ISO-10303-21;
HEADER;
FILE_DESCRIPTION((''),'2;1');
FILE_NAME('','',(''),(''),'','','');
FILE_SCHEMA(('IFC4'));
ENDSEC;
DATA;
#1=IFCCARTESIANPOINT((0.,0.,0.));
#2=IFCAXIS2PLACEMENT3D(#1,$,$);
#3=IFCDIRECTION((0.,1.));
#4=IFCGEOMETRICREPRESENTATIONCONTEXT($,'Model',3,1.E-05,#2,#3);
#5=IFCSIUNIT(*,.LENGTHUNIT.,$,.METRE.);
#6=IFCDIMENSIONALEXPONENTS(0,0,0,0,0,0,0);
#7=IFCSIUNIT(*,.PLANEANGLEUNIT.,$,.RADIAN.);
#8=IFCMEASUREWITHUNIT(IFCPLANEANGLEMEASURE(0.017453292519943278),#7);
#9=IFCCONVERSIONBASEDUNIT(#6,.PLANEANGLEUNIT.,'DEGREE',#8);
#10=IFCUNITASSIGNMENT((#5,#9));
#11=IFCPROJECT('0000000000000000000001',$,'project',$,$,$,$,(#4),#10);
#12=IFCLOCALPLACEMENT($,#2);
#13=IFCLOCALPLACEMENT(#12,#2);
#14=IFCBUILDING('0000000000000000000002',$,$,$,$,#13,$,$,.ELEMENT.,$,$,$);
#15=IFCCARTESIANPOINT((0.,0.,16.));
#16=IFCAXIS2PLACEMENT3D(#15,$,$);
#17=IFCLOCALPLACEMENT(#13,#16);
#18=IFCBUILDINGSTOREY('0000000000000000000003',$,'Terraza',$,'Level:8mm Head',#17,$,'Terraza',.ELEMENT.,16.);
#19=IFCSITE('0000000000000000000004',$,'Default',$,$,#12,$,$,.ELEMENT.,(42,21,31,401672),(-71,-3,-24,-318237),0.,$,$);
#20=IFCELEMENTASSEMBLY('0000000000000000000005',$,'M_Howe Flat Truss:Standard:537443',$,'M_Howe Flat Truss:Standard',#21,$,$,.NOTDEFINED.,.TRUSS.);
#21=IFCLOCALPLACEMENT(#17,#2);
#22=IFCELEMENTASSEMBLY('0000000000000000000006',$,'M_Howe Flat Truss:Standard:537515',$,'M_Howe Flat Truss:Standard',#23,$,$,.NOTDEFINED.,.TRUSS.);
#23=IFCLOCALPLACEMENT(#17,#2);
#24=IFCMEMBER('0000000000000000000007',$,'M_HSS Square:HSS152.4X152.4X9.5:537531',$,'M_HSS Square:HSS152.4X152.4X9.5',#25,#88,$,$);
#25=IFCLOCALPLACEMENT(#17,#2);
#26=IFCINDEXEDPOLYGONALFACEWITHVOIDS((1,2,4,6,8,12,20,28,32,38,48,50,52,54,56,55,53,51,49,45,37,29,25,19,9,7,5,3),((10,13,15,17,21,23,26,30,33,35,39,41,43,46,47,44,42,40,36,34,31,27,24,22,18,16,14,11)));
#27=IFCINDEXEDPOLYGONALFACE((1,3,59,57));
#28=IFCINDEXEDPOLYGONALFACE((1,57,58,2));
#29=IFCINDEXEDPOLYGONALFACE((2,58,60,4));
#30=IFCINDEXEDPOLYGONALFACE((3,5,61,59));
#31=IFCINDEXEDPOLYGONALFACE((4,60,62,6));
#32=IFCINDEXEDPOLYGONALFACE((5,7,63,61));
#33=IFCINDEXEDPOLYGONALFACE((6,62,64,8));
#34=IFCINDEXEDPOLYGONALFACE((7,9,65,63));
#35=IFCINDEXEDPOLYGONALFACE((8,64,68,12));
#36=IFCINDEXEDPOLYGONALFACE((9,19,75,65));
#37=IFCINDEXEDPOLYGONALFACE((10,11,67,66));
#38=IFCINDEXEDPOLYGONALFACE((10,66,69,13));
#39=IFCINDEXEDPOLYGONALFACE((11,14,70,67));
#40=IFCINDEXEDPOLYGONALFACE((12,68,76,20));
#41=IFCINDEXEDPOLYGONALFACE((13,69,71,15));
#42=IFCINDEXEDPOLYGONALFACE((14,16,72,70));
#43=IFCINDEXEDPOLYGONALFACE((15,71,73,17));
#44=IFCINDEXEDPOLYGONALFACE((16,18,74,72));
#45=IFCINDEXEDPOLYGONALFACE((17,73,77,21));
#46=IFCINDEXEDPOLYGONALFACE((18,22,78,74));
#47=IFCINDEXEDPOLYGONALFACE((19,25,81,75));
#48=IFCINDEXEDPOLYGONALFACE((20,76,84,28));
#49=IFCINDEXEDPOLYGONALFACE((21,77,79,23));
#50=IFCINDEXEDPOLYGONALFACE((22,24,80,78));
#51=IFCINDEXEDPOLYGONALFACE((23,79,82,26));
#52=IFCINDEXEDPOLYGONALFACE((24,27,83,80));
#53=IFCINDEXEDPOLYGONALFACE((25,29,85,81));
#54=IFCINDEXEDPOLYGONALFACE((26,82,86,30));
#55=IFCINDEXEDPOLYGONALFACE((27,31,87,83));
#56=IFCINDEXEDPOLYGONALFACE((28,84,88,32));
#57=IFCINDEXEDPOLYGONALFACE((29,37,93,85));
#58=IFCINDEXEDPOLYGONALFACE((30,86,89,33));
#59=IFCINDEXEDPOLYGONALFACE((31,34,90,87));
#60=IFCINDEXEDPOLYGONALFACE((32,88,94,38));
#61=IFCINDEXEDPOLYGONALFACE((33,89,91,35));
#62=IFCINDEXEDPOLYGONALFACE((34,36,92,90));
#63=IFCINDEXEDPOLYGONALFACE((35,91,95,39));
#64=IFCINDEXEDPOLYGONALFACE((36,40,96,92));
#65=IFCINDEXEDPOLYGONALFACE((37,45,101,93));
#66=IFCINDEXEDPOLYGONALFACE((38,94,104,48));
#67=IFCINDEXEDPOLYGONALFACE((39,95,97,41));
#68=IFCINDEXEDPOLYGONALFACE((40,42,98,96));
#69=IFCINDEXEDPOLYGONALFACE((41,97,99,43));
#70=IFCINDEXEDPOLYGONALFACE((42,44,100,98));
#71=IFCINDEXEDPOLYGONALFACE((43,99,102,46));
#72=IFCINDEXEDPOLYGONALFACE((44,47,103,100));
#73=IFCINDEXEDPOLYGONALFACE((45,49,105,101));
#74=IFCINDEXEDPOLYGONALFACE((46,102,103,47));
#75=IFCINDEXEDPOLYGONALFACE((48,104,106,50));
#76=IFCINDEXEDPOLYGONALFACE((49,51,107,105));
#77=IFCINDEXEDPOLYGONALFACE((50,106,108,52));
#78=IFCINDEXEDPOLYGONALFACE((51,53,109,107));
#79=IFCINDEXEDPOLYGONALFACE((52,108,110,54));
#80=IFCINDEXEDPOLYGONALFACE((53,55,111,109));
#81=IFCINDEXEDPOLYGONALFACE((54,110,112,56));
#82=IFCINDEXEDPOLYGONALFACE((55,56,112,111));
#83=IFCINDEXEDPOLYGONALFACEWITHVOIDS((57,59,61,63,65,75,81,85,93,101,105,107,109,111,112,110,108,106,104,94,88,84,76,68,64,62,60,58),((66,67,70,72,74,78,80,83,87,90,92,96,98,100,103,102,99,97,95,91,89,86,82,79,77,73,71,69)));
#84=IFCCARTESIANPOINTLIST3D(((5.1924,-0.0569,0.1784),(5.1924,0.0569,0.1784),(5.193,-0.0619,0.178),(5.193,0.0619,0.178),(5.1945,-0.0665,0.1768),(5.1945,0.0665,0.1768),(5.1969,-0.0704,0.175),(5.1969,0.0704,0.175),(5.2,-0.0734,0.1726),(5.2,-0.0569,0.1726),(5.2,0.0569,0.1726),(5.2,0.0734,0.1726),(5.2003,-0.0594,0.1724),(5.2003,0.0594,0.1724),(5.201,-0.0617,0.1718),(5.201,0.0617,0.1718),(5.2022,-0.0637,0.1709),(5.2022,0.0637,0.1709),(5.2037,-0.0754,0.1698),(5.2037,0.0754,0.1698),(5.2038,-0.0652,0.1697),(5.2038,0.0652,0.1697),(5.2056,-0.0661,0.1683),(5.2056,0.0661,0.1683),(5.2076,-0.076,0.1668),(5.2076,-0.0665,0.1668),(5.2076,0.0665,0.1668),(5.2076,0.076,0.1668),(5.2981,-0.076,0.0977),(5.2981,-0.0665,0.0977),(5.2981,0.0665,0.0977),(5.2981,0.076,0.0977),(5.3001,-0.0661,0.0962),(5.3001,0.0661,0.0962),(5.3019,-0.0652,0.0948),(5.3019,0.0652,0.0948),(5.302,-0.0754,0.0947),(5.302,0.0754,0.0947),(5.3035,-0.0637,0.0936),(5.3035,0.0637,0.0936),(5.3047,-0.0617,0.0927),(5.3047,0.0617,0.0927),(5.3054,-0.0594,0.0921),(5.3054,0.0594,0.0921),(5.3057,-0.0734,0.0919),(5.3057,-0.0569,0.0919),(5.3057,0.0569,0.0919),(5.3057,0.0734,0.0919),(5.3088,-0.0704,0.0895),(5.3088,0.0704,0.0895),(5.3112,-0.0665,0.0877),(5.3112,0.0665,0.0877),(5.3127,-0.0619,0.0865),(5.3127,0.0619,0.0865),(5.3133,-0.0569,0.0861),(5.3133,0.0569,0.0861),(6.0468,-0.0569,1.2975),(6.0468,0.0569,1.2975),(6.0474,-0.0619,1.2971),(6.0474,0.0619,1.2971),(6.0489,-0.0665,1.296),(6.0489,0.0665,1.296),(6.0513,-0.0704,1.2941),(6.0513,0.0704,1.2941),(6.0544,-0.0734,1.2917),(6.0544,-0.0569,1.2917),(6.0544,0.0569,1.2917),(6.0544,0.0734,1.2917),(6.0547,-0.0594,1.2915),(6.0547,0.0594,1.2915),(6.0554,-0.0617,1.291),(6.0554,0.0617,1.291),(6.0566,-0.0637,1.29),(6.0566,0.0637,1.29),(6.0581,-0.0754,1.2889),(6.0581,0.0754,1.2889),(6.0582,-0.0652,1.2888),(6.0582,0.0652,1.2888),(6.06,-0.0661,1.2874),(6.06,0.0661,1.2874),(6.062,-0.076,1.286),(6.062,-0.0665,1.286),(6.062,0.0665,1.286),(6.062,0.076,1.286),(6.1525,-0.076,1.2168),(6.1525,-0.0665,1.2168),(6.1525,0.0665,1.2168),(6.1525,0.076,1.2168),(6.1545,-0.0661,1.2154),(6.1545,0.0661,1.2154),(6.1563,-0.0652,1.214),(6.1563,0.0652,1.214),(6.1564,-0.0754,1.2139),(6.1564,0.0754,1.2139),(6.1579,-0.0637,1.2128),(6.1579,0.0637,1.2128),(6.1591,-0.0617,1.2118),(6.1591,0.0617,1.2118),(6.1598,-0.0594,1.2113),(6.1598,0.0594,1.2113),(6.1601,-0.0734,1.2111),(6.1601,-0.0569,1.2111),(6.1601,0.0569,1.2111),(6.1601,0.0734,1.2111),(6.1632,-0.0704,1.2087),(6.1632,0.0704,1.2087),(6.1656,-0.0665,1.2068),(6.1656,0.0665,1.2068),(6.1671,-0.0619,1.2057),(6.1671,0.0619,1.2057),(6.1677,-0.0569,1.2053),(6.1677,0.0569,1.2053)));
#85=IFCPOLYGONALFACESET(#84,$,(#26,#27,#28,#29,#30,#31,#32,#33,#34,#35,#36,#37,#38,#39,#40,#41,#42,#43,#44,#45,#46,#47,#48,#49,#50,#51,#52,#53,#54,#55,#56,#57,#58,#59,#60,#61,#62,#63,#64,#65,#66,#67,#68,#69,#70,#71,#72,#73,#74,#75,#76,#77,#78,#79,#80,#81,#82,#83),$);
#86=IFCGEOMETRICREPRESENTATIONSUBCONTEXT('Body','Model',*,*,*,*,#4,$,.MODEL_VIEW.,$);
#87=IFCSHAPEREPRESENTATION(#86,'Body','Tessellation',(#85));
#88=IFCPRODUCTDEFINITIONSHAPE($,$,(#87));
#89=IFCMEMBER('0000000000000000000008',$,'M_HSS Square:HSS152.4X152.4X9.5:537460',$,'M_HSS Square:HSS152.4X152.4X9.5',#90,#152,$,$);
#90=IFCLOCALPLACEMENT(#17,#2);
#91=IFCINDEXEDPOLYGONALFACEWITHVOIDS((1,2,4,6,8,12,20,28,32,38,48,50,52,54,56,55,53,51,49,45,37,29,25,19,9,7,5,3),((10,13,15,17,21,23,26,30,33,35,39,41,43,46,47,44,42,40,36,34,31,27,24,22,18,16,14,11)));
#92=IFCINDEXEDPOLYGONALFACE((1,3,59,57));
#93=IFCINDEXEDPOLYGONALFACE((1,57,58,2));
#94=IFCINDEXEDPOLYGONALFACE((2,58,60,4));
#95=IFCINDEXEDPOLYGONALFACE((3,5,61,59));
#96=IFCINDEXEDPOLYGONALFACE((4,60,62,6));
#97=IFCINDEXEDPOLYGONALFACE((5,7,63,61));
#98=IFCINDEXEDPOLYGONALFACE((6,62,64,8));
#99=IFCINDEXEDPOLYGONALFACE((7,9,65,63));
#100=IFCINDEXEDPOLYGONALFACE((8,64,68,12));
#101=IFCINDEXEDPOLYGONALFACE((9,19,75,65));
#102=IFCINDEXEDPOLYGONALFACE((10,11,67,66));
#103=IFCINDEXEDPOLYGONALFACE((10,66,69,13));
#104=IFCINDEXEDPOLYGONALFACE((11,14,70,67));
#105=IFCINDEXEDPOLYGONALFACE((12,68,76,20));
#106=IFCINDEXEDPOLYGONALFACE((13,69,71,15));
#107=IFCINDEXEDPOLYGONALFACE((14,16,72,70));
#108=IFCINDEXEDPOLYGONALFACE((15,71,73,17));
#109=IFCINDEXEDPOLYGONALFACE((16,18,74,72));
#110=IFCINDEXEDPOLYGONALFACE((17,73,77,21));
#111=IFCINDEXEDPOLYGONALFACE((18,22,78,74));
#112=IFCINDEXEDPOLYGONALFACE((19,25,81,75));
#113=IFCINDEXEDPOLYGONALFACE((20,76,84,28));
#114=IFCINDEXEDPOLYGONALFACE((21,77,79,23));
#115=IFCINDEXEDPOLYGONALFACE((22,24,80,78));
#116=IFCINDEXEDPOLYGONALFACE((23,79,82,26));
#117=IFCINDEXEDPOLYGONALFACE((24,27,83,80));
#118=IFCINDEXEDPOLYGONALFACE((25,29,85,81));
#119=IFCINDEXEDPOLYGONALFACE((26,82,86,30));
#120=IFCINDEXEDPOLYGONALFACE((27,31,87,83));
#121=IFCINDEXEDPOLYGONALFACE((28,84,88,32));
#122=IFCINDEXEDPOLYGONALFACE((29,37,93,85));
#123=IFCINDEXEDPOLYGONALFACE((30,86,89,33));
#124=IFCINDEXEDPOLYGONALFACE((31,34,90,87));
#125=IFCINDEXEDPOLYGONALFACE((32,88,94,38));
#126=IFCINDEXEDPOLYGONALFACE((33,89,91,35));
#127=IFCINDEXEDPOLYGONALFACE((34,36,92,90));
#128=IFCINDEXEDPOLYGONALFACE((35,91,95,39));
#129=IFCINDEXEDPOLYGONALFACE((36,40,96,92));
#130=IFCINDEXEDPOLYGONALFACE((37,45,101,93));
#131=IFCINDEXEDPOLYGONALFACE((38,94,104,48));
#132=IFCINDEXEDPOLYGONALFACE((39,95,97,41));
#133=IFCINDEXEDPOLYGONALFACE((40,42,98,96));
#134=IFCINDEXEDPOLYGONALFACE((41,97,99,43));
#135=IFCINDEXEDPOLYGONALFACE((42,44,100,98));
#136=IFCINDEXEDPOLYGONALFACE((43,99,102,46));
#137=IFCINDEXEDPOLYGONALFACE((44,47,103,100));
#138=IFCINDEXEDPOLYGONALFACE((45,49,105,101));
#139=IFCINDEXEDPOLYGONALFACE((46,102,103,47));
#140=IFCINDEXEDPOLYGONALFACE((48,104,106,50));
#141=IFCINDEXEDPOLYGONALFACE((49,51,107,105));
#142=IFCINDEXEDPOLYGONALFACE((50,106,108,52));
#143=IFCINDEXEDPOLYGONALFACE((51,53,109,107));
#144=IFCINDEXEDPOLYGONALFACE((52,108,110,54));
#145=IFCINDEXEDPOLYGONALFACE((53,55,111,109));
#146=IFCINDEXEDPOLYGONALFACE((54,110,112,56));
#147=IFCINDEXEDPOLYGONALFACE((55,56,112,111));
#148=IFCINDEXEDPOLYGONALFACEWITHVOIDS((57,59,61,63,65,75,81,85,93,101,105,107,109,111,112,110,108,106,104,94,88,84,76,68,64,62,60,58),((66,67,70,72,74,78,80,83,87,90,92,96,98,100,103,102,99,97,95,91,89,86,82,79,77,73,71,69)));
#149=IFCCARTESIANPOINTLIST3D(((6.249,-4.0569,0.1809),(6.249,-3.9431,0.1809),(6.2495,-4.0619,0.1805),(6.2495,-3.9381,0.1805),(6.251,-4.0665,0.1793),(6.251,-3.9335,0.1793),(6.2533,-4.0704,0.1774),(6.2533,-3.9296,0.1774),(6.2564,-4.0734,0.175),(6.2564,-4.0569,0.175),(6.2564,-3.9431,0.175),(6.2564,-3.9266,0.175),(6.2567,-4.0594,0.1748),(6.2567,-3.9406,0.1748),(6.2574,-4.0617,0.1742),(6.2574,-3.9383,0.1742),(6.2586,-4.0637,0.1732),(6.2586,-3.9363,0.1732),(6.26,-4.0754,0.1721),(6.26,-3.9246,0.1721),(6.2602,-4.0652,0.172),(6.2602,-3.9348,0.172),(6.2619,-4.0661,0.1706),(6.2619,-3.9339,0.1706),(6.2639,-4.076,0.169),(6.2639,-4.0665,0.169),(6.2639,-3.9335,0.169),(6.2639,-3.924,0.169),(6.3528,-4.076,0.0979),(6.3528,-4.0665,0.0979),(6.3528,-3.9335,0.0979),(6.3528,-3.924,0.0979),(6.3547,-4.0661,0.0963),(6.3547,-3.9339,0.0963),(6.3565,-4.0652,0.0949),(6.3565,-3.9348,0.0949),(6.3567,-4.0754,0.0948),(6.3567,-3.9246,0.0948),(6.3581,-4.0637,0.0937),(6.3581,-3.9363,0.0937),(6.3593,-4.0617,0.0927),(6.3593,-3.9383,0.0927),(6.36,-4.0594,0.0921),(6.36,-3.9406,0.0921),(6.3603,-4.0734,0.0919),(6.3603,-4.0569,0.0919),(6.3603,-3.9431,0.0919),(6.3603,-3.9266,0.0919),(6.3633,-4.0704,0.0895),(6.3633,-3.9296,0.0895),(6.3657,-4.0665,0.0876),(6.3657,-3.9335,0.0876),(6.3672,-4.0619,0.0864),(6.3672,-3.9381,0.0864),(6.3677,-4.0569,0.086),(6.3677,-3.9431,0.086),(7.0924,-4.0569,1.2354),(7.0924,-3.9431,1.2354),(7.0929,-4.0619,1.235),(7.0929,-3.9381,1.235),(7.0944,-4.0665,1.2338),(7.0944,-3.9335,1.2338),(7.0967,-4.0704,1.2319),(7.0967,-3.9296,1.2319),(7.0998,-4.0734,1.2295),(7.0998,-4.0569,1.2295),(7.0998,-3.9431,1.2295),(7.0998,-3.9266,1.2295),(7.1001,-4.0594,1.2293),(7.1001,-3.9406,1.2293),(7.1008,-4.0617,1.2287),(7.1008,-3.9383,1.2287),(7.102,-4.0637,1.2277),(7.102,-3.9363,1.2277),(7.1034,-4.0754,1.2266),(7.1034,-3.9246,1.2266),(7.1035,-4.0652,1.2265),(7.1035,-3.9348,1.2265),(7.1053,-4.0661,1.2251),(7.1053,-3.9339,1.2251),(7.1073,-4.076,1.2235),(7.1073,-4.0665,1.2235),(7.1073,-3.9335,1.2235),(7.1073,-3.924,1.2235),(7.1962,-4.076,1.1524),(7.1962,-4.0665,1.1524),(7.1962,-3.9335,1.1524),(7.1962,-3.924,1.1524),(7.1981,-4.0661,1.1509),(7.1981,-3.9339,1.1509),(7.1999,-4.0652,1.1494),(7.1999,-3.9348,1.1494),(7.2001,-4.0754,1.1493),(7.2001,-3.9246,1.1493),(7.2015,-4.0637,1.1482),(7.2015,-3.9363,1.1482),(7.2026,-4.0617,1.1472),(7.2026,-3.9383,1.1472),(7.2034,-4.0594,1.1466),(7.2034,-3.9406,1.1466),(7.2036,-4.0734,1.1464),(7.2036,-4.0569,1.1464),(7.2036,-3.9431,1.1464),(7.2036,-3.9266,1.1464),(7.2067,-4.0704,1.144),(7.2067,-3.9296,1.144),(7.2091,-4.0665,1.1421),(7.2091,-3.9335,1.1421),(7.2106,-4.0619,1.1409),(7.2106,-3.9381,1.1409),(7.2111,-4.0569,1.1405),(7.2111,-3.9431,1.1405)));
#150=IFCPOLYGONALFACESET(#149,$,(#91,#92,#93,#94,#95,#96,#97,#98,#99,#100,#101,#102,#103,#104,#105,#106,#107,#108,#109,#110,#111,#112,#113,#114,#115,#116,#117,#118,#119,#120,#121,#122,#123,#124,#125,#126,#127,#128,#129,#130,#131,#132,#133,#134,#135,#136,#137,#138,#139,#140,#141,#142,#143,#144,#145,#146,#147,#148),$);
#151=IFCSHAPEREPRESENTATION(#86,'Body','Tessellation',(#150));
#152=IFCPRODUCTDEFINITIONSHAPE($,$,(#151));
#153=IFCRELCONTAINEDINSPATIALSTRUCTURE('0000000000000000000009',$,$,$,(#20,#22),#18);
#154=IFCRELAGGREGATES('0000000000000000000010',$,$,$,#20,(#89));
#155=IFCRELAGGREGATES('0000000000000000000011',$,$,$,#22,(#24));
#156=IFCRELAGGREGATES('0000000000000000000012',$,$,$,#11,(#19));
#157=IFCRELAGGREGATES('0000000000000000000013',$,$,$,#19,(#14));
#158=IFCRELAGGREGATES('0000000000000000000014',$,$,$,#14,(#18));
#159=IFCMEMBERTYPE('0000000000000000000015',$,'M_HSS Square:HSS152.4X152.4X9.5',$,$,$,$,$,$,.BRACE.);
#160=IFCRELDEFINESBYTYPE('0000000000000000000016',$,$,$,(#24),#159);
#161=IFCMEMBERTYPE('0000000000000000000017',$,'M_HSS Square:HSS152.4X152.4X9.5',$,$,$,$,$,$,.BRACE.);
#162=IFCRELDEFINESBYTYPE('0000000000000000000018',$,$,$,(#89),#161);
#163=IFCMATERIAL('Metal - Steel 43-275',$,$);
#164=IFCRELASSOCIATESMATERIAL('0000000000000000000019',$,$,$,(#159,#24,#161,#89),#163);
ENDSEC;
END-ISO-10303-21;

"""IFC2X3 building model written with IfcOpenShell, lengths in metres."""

from ifc_helpers import new_model, entity, si_unit, converted_unit, direction, frame, frame_2d, origin, place, context, subcontext, project, spatial, polyline, circle_curve, parameter, trimmed, segment, composite_curve, outline, extrude, source, transform, mapped, material, type_object, type_shapes, element, aggregate, save


model = new_model("IFC2X3")

# Units and contexts
model_context = context("Model", 3, precision=1e-05, world=origin(), true_north=direction((0.0, 1.0)))
body_context = subcontext(model_context, "Body", "Model", "MODEL_VIEW")
ifc_project = project(units=[si_unit("LENGTHUNIT", "METRE"), converted_unit("PLANEANGLEUNIT", "DEGREE", entity("IfcPlaneAngleMeasure", 0.017453292519943278), si_unit("PLANEANGLEUNIT", "RADIAN"), dimensions=[0, 0, 0, 0, 0, 0, 0])], contexts=[model_context])

# Site, building, storey
site_placement = place(None, origin())
site = spatial("IfcSite", under=ifc_project, at=site_placement, Name="Default", CompositionType="ELEMENT", RefLatitude=(42, 21, 31, 401672), RefLongitude=(-71, -3, -24, -318237), RefElevation=0.0)
building_placement = place(site_placement, origin())
building = spatial("IfcBuilding", under=site, at=building_placement, CompositionType="ELEMENT")
storey_placement = place(building_placement, frame((0.0, 0.0, 16.0)))
storey = spatial("IfcBuildingStorey", under=building, at=storey_placement, Name="Terraza", ObjectType="Level:8mm Head", LongName="Terraza", CompositionType="ELEMENT", Elevation=16.0)

# Element assemblies
ifc_material_1 = material(Name="Metal - Steel 43-275")
assembly_1_placement = place(storey_placement, origin())
assembly_1 = element("IfcElementAssembly", 1, at=assembly_1_placement, inside=storey, Name="M_Howe Flat Truss:Standard:537443", ObjectType="M_Howe Flat Truss:Standard", AssemblyPlace="NOTDEFINED", PredefinedType="TRUSS")
assembly_2_placement = place(storey_placement, origin())
assembly_2 = element("IfcElementAssembly", 2, at=assembly_2_placement, inside=storey, Name="M_Howe Flat Truss:Standard:537515", ObjectType="M_Howe Flat Truss:Standard", AssemblyPlace="NOTDEFINED", PredefinedType="TRUSS")

# Members
member_type_1 = type_object("IfcMemberType", Name="M_HSS Square:HSS152.4X152.4X9.5", PredefinedType="BRACE", material=ifc_material_1)
shared_shape_1 = source(origin(), body_context, "Body", "SweptSolid", [
    extrude(outline(composite_curve([segment(polyline([(-0.0569, -0.076), (0.0569, -0.076)]), True, "CONTINUOUS"), segment(trimmed(circle_curve(frame_2d((0.0569, -0.0569), x_axis=(0.0, 1.0)), 0.0191), [parameter(180.0)], [parameter(270.0)], True, "PARAMETER"), True, "CONTINUOUS"), segment(polyline([(0.076, -0.0569), (0.076, 0.0569)]), True, "CONTINUOUS"), segment(trimmed(circle_curve(frame_2d((0.0569, 0.0569), x_axis=(0.0, 1.0)), 0.0191), [parameter(270.0)], [parameter(0.0)], True, "PARAMETER"), True, "CONTINUOUS"), segment(polyline([(0.0569, 0.076), (-0.0569, 0.076)]), True, "CONTINUOUS"), segment(trimmed(circle_curve(frame_2d((-0.0569, 0.0569), x_axis=(0.0, 1.0)), 0.0191), [parameter(0.0)], [parameter(90.0)], True, "PARAMETER"), True, "CONTINUOUS"), segment(polyline([(-0.076, 0.0569), (-0.076, -0.0569)]), True, "CONTINUOUS"), segment(trimmed(circle_curve(frame_2d((-0.0569, -0.0569), x_axis=(0.0, 1.0)), 0.0191), [parameter(90.0)], [parameter(180.0)], True, "PARAMETER"), True, "CONTINUOUS")], self_intersect=False), holes=[composite_curve([segment(trimmed(circle_curve(frame_2d((-0.0569, 0.0569), x_axis=(0.0, 1.0)), 0.0095), [parameter(360.0)], [parameter(90.0)], True, "PARAMETER"), False, "CONTINUOUS"), segment(polyline([(-0.0569, 0.0665), (0.0569, 0.0665)]), True, "CONTINUOUS"), segment(trimmed(circle_curve(frame_2d((0.0569, 0.0569), x_axis=(0.0, 1.0)), 0.0095), [parameter(270.0)], [parameter(360.0)], True, "PARAMETER"), False, "CONTINUOUS"), segment(polyline([(0.0665, 0.0569), (0.0665, -0.0569)]), True, "CONTINUOUS"), segment(trimmed(circle_curve(frame_2d((0.0569, -0.0569), x_axis=(0.0, 1.0)), 0.0095), [parameter(180.0)], [parameter(270.0)], True, "PARAMETER"), False, "CONTINUOUS"), segment(polyline([(0.0569, -0.0665), (-0.0569, -0.0665)]), True, "CONTINUOUS"), segment(trimmed(circle_curve(frame_2d((-0.0569, -0.0569), x_axis=(0.0, 1.0)), 0.0095), [parameter(90.0)], [parameter(180.0)], True, "PARAMETER"), False, "CONTINUOUS"), segment(polyline([(-0.0665, -0.0569), (-0.0665, 0.0569)]), True, "CONTINUOUS")], self_intersect=False)]), frame((-0.6986, 0.0, 0.0), z_axis=(1.0, 0.0, 0.0), x_axis=(0.0, 0.0, -1.0)), (0.0, 0.0, 1.0), 1.408),
])
type_shapes(member_type_1, [shared_shape_1])
member_1_placement = place(assembly_2_placement, frame((5.6767, 0.0, 0.6875), z_axis=(0.794843, 0.0, -0.606815), x_axis=(0.606815, 0.0, 0.794843)))
member_1 = element("IfcMember", 3, at=member_1_placement, type_object=member_type_1, material=ifc_material_1, Name="M_HSS Square:HSS152.4X152.4X9.5:537531", ObjectType="M_HSS Square:HSS152.4X152.4X9.5", context=body_context, shape_type="MappedRepresentation", body=[
    mapped(shared_shape_1, transform((0.0, 0.0, 0.0), scale=1.0)),
])
member_type_2 = type_object("IfcMemberType", Name="M_HSS Square:HSS152.4X152.4X9.5", PredefinedType="BRACE", material=ifc_material_1)
shared_shape_2 = source(origin(), body_context, "Body", "SweptSolid", [
    extrude(outline(composite_curve([segment(polyline([(-0.0569, -0.076), (0.0569, -0.076)]), True, "CONTINUOUS"), segment(trimmed(circle_curve(frame_2d((0.0569, -0.0569), x_axis=(0.0, 1.0)), 0.0191), [parameter(180.0)], [parameter(270.0)], True, "PARAMETER"), True, "CONTINUOUS"), segment(polyline([(0.076, -0.0569), (0.076, 0.0569)]), True, "CONTINUOUS"), segment(trimmed(circle_curve(frame_2d((0.0569, 0.0569), x_axis=(0.0, 1.0)), 0.0191), [parameter(270.0)], [parameter(0.0)], True, "PARAMETER"), True, "CONTINUOUS"), segment(polyline([(0.0569, 0.076), (-0.0569, 0.076)]), True, "CONTINUOUS"), segment(trimmed(circle_curve(frame_2d((-0.0569, 0.0569), x_axis=(0.0, 1.0)), 0.0191), [parameter(0.0)], [parameter(90.0)], True, "PARAMETER"), True, "CONTINUOUS"), segment(polyline([(-0.076, 0.0569), (-0.076, -0.0569)]), True, "CONTINUOUS"), segment(trimmed(circle_curve(frame_2d((-0.0569, -0.0569), x_axis=(0.0, 1.0)), 0.0191), [parameter(90.0)], [parameter(180.0)], True, "PARAMETER"), True, "CONTINUOUS")], self_intersect=False), holes=[composite_curve([segment(trimmed(circle_curve(frame_2d((-0.0569, 0.0569), x_axis=(0.0, 1.0)), 0.0095), [parameter(360.0)], [parameter(90.0)], True, "PARAMETER"), False, "CONTINUOUS"), segment(polyline([(-0.0569, 0.0665), (0.0569, 0.0665)]), True, "CONTINUOUS"), segment(trimmed(circle_curve(frame_2d((0.0569, 0.0569), x_axis=(0.0, 1.0)), 0.0095), [parameter(270.0)], [parameter(360.0)], True, "PARAMETER"), False, "CONTINUOUS"), segment(polyline([(0.0665, 0.0569), (0.0665, -0.0569)]), True, "CONTINUOUS"), segment(trimmed(circle_curve(frame_2d((0.0569, -0.0569), x_axis=(0.0, 1.0)), 0.0095), [parameter(180.0)], [parameter(270.0)], True, "PARAMETER"), False, "CONTINUOUS"), segment(polyline([(0.0569, -0.0665), (-0.0569, -0.0665)]), True, "CONTINUOUS"), segment(trimmed(circle_curve(frame_2d((-0.0569, -0.0569), x_axis=(0.0, 1.0)), 0.0095), [parameter(90.0)], [parameter(180.0)], True, "PARAMETER"), False, "CONTINUOUS"), segment(polyline([(-0.0665, -0.0569), (-0.0665, 0.0569)]), True, "CONTINUOUS")], self_intersect=False)]), frame((-0.6695, 0.0, 0.0), z_axis=(1.0, 0.0, 0.0), x_axis=(0.0, 0.0, -1.0)), (0.0, 0.0, 1.0), 1.3503),
])
type_shapes(member_type_2, [shared_shape_2])
member_2_placement = place(assembly_1_placement, frame((6.7265, -4.0, 0.6562), z_axis=(0.780947, 0.0, -0.624598), x_axis=(0.624598, 0.0, 0.780947)))
member_2 = element("IfcMember", 4, at=member_2_placement, type_object=member_type_2, material=ifc_material_1, Name="M_HSS Square:HSS152.4X152.4X9.5:537460", ObjectType="M_HSS Square:HSS152.4X152.4X9.5", context=body_context, shape_type="MappedRepresentation", body=[
    mapped(shared_shape_2, transform((0.0, 0.0, 0.0), scale=1.0)),
])
aggregate(assembly_1, [member_2])
aggregate(assembly_2, [member_1])

save(model, "model.ifc")
